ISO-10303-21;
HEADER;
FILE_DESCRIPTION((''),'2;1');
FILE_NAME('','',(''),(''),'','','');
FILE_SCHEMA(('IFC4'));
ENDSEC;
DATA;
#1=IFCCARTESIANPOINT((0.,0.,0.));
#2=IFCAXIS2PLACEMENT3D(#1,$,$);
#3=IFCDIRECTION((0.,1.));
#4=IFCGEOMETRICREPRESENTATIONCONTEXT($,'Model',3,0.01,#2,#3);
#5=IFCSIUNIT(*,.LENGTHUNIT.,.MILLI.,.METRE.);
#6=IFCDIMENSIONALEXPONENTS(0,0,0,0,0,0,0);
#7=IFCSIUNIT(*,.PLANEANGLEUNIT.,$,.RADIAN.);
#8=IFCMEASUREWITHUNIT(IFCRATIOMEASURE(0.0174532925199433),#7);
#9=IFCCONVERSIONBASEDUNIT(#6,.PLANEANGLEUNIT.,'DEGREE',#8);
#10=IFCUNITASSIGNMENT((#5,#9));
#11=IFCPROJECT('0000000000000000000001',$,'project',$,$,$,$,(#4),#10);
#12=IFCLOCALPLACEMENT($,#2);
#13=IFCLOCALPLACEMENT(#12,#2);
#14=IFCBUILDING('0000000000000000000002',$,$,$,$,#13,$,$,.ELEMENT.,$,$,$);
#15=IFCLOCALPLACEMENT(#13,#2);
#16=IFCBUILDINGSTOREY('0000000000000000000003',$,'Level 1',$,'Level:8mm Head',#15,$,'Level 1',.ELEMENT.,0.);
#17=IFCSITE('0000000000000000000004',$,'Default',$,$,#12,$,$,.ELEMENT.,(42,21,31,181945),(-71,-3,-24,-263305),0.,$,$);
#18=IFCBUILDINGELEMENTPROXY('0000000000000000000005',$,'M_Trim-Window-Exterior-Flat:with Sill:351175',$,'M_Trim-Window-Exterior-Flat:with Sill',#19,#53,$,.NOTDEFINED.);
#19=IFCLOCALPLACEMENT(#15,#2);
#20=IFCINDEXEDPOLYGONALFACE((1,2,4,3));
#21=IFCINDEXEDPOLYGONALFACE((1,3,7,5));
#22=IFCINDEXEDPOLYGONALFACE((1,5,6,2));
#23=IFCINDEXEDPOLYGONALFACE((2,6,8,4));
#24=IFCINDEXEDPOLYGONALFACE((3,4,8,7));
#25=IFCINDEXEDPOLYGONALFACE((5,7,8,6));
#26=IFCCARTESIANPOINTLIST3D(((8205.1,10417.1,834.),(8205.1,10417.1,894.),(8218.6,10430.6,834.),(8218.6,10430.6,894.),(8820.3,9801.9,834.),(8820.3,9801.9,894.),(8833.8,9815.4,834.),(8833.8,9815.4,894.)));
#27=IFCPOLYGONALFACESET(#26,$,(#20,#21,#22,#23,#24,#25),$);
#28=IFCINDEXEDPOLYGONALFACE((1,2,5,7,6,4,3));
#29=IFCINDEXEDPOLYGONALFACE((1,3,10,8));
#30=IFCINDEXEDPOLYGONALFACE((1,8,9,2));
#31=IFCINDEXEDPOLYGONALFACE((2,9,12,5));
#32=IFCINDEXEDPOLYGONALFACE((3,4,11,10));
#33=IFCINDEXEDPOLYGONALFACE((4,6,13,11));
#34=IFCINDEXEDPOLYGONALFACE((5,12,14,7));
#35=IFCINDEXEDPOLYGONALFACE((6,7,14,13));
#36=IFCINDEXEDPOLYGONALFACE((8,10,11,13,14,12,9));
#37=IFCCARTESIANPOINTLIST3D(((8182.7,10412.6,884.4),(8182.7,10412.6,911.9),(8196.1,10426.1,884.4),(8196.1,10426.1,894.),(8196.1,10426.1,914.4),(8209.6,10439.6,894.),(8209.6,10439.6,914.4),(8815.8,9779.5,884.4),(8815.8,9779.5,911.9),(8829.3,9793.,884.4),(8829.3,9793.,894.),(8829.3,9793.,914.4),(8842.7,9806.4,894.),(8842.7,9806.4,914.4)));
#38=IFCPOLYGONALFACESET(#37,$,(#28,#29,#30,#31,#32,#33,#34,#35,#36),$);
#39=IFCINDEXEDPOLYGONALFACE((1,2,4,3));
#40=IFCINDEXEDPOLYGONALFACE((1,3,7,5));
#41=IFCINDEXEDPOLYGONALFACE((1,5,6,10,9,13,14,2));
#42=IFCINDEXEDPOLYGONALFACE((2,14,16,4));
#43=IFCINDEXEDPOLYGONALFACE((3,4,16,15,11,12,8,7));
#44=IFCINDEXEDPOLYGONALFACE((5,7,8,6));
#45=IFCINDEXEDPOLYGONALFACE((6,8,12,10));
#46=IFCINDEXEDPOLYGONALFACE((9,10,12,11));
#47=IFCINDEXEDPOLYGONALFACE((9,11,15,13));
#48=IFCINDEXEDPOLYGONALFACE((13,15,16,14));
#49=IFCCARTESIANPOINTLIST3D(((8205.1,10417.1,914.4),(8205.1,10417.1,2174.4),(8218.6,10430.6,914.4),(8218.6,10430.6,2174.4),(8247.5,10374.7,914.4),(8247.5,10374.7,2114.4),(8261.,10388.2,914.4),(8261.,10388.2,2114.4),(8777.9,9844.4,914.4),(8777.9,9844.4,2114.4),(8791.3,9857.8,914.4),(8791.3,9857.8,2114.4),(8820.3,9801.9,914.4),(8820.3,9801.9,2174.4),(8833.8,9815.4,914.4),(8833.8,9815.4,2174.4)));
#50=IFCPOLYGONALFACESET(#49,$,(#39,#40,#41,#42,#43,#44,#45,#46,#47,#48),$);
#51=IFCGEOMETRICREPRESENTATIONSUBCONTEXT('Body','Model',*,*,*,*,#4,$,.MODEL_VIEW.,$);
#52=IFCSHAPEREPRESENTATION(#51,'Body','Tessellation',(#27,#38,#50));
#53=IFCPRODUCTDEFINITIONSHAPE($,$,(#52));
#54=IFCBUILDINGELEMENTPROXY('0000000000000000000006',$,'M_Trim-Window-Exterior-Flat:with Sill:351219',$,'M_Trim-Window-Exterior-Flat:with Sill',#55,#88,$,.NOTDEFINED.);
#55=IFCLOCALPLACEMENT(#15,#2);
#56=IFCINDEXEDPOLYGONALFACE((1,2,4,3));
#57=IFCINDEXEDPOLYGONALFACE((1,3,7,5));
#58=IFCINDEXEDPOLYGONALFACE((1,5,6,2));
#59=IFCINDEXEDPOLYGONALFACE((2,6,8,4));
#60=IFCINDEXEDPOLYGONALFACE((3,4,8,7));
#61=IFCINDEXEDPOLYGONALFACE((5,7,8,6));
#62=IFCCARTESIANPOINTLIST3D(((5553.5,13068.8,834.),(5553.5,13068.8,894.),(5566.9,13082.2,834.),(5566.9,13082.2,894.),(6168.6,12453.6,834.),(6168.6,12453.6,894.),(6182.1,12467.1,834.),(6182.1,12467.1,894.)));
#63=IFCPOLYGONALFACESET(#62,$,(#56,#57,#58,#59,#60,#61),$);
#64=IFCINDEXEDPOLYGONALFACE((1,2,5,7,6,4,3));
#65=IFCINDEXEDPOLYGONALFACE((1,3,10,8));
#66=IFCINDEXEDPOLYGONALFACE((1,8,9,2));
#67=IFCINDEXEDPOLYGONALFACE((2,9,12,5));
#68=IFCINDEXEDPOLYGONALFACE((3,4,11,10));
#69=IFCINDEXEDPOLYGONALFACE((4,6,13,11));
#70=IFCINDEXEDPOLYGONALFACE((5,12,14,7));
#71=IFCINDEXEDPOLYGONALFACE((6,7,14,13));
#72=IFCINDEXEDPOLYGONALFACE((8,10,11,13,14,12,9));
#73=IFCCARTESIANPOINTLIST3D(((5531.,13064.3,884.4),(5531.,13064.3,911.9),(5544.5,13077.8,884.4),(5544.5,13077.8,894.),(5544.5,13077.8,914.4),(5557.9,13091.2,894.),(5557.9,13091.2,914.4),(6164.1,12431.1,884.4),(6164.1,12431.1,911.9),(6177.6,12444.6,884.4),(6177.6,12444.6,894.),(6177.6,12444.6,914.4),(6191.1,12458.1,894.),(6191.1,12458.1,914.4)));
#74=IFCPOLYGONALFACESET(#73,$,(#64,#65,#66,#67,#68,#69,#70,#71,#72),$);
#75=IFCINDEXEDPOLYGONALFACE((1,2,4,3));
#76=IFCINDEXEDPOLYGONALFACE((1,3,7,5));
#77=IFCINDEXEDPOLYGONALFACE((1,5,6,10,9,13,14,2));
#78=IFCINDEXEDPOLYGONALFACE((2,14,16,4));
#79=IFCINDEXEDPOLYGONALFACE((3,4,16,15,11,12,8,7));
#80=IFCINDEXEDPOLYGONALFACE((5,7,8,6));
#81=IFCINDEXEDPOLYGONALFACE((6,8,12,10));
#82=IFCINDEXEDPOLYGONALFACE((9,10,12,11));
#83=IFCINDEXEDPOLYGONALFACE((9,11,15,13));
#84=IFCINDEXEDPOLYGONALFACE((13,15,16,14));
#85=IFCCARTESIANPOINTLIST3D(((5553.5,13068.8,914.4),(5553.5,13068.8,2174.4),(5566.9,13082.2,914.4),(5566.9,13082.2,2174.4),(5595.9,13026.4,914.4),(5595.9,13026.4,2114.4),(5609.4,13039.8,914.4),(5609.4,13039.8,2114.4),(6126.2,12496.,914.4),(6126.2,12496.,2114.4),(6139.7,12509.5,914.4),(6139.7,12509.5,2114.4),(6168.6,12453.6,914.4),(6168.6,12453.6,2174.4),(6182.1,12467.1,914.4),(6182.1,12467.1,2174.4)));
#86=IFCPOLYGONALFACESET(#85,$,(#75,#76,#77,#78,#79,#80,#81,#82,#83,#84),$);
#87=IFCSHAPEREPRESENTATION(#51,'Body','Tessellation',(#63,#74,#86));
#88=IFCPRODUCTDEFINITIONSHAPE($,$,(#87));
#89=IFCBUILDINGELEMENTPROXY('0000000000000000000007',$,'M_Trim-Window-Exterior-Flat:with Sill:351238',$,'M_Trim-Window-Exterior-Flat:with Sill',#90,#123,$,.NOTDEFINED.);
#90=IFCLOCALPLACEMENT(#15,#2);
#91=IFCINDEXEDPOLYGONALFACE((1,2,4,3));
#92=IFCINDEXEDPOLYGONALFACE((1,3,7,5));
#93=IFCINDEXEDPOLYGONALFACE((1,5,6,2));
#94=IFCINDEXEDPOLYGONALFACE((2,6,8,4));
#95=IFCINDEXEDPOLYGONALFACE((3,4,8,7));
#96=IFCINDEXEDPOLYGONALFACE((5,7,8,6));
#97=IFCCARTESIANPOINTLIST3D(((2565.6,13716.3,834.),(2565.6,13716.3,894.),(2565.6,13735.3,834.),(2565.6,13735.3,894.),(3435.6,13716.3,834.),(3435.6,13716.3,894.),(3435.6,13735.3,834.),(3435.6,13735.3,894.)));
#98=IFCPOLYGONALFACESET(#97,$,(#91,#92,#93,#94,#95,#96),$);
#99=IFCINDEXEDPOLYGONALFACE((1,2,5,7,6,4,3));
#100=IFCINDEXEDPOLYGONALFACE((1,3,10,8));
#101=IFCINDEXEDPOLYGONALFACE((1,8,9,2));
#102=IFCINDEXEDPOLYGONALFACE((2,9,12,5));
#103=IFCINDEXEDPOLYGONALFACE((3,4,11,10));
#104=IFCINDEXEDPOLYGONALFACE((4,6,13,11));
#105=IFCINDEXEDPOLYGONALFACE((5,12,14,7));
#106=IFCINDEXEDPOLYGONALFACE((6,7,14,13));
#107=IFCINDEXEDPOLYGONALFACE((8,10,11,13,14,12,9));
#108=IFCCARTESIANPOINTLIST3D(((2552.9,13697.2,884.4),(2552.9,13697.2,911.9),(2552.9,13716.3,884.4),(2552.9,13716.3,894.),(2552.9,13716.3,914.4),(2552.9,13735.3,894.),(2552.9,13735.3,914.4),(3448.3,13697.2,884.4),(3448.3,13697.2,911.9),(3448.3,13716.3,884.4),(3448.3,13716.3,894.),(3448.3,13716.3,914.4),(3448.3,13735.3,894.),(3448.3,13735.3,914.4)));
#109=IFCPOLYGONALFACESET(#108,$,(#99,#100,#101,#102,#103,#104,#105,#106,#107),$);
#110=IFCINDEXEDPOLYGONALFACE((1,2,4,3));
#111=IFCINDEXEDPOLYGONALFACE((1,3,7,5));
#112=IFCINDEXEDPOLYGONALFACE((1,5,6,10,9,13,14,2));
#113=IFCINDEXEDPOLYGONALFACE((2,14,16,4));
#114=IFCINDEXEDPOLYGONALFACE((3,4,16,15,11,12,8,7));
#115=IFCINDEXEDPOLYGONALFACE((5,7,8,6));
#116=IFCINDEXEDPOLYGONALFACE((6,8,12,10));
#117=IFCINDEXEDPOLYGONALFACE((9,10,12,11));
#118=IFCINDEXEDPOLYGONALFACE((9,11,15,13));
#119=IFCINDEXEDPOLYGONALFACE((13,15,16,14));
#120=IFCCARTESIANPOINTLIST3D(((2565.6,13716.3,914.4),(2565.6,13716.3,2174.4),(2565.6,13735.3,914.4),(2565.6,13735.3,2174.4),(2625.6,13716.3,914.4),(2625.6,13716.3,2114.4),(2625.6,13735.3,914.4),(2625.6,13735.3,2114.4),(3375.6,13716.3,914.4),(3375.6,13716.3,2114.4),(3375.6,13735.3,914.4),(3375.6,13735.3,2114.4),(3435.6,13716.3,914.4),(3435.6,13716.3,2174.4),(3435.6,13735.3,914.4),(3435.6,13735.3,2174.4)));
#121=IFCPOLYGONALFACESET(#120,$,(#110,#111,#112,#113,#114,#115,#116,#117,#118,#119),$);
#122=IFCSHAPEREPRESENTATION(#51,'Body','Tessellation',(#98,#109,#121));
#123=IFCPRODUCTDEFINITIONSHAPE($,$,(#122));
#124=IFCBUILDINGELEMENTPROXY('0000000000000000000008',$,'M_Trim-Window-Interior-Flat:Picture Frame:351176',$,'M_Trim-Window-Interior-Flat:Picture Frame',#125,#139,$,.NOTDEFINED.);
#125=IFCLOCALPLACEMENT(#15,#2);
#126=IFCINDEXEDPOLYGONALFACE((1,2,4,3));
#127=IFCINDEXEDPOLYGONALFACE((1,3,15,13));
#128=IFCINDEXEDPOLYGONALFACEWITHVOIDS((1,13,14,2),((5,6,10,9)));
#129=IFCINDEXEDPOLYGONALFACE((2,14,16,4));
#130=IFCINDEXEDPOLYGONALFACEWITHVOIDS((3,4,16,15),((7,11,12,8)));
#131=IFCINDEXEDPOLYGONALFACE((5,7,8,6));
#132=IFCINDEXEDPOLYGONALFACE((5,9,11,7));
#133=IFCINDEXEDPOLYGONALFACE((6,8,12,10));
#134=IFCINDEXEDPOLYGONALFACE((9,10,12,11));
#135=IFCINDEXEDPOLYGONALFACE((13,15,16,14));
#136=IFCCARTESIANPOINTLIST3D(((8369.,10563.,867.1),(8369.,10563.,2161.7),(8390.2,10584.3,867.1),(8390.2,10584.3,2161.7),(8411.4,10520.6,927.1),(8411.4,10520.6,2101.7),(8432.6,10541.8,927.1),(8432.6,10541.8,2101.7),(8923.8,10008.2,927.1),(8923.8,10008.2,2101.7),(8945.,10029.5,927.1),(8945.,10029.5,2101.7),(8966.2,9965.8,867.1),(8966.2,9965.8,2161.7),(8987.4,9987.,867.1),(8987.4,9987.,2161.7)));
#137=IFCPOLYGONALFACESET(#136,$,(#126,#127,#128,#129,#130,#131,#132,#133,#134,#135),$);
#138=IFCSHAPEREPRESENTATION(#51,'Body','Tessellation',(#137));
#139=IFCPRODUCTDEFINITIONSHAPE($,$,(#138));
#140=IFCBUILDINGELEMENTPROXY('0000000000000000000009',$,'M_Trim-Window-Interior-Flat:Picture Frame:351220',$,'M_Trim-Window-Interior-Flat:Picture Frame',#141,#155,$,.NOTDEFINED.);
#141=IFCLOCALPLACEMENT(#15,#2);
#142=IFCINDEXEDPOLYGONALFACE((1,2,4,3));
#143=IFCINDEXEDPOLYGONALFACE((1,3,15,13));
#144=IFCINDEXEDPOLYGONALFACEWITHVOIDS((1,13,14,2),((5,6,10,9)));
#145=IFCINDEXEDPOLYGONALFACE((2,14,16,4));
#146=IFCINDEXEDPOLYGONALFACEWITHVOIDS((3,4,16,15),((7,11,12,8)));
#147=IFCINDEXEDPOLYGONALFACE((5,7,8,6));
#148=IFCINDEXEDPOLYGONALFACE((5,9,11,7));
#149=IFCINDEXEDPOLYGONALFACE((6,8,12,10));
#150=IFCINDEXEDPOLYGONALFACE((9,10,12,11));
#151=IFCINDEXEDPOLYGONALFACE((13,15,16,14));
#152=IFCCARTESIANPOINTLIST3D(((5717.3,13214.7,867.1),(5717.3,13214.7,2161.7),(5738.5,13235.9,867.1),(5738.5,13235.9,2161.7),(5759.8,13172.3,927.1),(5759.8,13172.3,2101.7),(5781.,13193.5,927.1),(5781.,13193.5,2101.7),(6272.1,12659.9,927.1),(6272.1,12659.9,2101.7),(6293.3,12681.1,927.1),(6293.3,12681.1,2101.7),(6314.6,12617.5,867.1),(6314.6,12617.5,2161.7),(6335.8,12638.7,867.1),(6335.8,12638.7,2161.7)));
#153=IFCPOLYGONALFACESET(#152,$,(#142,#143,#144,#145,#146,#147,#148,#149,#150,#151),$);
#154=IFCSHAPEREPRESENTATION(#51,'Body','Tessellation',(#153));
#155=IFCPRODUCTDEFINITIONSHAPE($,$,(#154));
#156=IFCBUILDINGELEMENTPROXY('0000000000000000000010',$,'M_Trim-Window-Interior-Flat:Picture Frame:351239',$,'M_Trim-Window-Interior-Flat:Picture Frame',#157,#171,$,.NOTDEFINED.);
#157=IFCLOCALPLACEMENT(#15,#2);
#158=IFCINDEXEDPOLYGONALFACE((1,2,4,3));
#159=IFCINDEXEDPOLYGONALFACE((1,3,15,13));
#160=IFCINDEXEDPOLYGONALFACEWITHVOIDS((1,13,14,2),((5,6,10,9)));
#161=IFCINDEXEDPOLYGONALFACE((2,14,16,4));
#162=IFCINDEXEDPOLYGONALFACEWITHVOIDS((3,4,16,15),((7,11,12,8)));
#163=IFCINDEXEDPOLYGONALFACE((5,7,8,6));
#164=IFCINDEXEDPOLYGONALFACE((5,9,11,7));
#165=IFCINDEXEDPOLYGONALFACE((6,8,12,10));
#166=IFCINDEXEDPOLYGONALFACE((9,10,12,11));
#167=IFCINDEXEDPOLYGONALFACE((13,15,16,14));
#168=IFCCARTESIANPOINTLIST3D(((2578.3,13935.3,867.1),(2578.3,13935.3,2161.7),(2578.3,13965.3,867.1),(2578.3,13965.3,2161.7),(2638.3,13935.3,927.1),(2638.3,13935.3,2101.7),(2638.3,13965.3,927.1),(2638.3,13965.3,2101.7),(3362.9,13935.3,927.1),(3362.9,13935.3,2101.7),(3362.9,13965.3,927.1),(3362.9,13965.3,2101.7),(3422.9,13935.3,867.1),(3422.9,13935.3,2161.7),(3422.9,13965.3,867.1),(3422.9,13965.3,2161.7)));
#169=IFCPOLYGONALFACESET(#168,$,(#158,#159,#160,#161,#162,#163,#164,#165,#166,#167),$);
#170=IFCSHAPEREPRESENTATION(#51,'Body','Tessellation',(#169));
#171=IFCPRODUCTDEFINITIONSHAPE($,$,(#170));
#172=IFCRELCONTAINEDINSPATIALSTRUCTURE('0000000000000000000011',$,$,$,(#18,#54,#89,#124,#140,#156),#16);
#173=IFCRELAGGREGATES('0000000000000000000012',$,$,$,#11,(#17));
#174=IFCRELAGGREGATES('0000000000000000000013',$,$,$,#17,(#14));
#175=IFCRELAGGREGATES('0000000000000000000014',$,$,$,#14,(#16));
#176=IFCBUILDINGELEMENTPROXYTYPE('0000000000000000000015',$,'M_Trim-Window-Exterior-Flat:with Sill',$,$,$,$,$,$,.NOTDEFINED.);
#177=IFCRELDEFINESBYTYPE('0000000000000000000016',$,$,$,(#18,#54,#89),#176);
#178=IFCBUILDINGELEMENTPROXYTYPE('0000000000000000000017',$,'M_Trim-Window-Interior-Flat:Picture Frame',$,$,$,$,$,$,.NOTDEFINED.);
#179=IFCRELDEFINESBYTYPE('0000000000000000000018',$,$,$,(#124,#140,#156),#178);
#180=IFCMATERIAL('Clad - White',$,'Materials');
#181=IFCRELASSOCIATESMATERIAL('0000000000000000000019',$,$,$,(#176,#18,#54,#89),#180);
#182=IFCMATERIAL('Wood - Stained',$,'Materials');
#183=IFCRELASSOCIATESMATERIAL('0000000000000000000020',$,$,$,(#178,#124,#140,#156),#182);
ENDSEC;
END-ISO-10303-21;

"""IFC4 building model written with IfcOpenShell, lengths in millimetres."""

from ifc_helpers import new_model, entity, si_unit, converted_unit, direction, frame, frame_2d, origin, place, context, subcontext, project, spatial, polyline, rectangle, outline, extrude, source, transform, mapped, material, type_object, type_shapes, element, save


model = new_model("IFC4")

# Units and contexts
model_context = context("Model", 3, precision=0.01, world=origin(), true_north=direction((0.0, 1.0)))
body_context = subcontext(model_context, "Body", "Model", "MODEL_VIEW")
ifc_project = project(units=[si_unit("LENGTHUNIT", "METRE", prefix="MILLI"), converted_unit("PLANEANGLEUNIT", "DEGREE", entity("IfcRatioMeasure", 0.0174532925199433), si_unit("PLANEANGLEUNIT", "RADIAN"), dimensions=[0, 0, 0, 0, 0, 0, 0])], contexts=[model_context])

# Site, building, storey
site_placement = place(None, origin())
site = spatial("IfcSite", under=ifc_project, at=site_placement, Name="Default", CompositionType="ELEMENT", RefLatitude=(42, 21, 31, 181945), RefLongitude=(-71, -3, -24, -263305), RefElevation=0.0)
building_placement = place(site_placement, origin())
building = spatial("IfcBuilding", under=site, at=building_placement, CompositionType="ELEMENT")
storey_placement = place(building_placement, origin())
storey = spatial("IfcBuildingStorey", under=building, at=storey_placement, Name="Level 1", ObjectType="Level:8mm Head", LongName="Level 1", CompositionType="ELEMENT", Elevation=0.0)

# Shared definitions
ifc_material_1 = material(Name="Wood - Stained", Category="Materials")

# Building element proxies
ifc_material_2 = material(Name="Clad - White", Category="Materials")
building_element_proxy_type_1 = type_object("IfcBuildingElementProxyType", Name="M_Trim-Window-Exterior-Flat:with Sill", PredefinedType="NOTDEFINED", material=ifc_material_2)
shared_shape_1 = source(origin(), body_context, "Body", "SweptSolid", [
    extrude(rectangle(XDim=870.0, YDim=60.0, at=frame_2d((0.0, 0.0), x_axis=(1.0, 0.0))), frame((0.0, -1250.4, 0.0), z_axis=(0.0, 0.0, 1.0), x_axis=(-1.0, 0.0, 0.0)), (0.0, 0.0, 1.0), 19.1),
    extrude(outline(polyline([(-19.0, -15.2), (0.0, -15.2), (0.0, -5.7), (19.0, -5.7), (19.0, 14.8), (0.0, 14.8), (-19.0, 12.3), (-19.0, -15.2)])), frame((-447.7, -1214.8, 19.0), z_axis=(1.0, 0.0, 0.0), x_axis=(0.0, 0.0, -1.0)), (0.0, 0.0, 1.0), 895.4),
    extrude(outline(polyline([(-645.0, -435.0), (615.0, -435.0), (615.0, -375.0), (-585.0, -375.0), (-585.0, 375.0), (615.0, 375.0), (615.0, 435.0), (-645.0, 435.0), (-645.0, -435.0)])), frame((0.0, -585.0, 0.0), z_axis=(0.0, 0.0, 1.0), x_axis=(0.0, -1.0, 0.0)), (0.0, 0.0, 1.0), 19.1),
])
type_shapes(building_element_proxy_type_1, [shared_shape_1])
for number, where, z_axis, x_axis, name in (
    (1, (8526.2, 10123.0, 2114.4), (-0.707107, -0.707107, 0.0), (0.707107, -0.707107, 0.0), "M_Trim-Window-Exterior-Flat:with Sill:351175"),
    (2, (5874.5, 12774.7, 2114.4), (-0.707107, -0.707107, 0.0), (0.707107, -0.707107, 0.0), "M_Trim-Window-Exterior-Flat:with Sill:351219"),
    (3, (3000.6, 13735.3, 2114.4), (0.0, -1.0, 0.0), (1.0, 0.0, 0.0), "M_Trim-Window-Exterior-Flat:with Sill:351238"),
):
    element("IfcBuildingElementProxy", number, at=place(storey_placement, frame(where, z_axis=z_axis, x_axis=x_axis)), inside=storey, type_object=building_element_proxy_type_1, material=ifc_material_2, Name=name, ObjectType="M_Trim-Window-Exterior-Flat:with Sill", PredefinedType="NOTDEFINED", context=body_context, shape_type="MappedRepresentation", body=[
        mapped(shared_shape_1, transform((0.0, 0.0, 0.0), scale=1.0)),
    ])
building_element_proxy_type_2 = type_object("IfcBuildingElementProxyType", Name="M_Trim-Window-Interior-Flat:Picture Frame", PredefinedType="NOTDEFINED", material=ifc_material_1)
shared_shape_2 = source(origin(), body_context, "Body", "SweptSolid", [
    extrude(outline(polyline([(-422.3, -647.3), (422.3, -647.3), (422.3, 647.3), (-422.3, 647.3), (-422.3, -647.3)]), holes=[polyline([(-362.3, -587.3), (-362.3, 587.3), (362.3, 587.3), (362.3, -587.3), (-362.3, -587.3)])]), frame((0.0, -600.0, 0.0), z_axis=(0.0, 0.0, 1.0), x_axis=(-1.0, 0.0, 0.0)), (0.0, 0.0, 1.0), 30.0),
])
type_shapes(building_element_proxy_type_2, [shared_shape_2])
for number, where, z_axis, x_axis, name in (
    (4, (8667.6, 10264.4, 2114.4), (0.707107, 0.707107, 0.0), (-0.707107, 0.707107, 0.0), "M_Trim-Window-Interior-Flat:Picture Frame:351176"),
    (5, (6015.9, 12916.1, 2114.4), (0.707107, 0.707107, 0.0), (-0.707107, 0.707107, 0.0), "M_Trim-Window-Interior-Flat:Picture Frame:351220"),
    (6, (3000.6, 13935.3, 2114.4), (0.0, 1.0, 0.0), (-1.0, 0.0, 0.0), "M_Trim-Window-Interior-Flat:Picture Frame:351239"),
):
    element("IfcBuildingElementProxy", number, at=place(storey_placement, frame(where, z_axis=z_axis, x_axis=x_axis)), inside=storey, type_object=building_element_proxy_type_2, material=ifc_material_1, Name=name, ObjectType="M_Trim-Window-Interior-Flat:Picture Frame", PredefinedType="NOTDEFINED", context=body_context, shape_type="MappedRepresentation", body=[
        mapped(shared_shape_2, transform((0.0, 0.0, 0.0), scale=1.0)),
    ])

save(model, "model.ifc")
